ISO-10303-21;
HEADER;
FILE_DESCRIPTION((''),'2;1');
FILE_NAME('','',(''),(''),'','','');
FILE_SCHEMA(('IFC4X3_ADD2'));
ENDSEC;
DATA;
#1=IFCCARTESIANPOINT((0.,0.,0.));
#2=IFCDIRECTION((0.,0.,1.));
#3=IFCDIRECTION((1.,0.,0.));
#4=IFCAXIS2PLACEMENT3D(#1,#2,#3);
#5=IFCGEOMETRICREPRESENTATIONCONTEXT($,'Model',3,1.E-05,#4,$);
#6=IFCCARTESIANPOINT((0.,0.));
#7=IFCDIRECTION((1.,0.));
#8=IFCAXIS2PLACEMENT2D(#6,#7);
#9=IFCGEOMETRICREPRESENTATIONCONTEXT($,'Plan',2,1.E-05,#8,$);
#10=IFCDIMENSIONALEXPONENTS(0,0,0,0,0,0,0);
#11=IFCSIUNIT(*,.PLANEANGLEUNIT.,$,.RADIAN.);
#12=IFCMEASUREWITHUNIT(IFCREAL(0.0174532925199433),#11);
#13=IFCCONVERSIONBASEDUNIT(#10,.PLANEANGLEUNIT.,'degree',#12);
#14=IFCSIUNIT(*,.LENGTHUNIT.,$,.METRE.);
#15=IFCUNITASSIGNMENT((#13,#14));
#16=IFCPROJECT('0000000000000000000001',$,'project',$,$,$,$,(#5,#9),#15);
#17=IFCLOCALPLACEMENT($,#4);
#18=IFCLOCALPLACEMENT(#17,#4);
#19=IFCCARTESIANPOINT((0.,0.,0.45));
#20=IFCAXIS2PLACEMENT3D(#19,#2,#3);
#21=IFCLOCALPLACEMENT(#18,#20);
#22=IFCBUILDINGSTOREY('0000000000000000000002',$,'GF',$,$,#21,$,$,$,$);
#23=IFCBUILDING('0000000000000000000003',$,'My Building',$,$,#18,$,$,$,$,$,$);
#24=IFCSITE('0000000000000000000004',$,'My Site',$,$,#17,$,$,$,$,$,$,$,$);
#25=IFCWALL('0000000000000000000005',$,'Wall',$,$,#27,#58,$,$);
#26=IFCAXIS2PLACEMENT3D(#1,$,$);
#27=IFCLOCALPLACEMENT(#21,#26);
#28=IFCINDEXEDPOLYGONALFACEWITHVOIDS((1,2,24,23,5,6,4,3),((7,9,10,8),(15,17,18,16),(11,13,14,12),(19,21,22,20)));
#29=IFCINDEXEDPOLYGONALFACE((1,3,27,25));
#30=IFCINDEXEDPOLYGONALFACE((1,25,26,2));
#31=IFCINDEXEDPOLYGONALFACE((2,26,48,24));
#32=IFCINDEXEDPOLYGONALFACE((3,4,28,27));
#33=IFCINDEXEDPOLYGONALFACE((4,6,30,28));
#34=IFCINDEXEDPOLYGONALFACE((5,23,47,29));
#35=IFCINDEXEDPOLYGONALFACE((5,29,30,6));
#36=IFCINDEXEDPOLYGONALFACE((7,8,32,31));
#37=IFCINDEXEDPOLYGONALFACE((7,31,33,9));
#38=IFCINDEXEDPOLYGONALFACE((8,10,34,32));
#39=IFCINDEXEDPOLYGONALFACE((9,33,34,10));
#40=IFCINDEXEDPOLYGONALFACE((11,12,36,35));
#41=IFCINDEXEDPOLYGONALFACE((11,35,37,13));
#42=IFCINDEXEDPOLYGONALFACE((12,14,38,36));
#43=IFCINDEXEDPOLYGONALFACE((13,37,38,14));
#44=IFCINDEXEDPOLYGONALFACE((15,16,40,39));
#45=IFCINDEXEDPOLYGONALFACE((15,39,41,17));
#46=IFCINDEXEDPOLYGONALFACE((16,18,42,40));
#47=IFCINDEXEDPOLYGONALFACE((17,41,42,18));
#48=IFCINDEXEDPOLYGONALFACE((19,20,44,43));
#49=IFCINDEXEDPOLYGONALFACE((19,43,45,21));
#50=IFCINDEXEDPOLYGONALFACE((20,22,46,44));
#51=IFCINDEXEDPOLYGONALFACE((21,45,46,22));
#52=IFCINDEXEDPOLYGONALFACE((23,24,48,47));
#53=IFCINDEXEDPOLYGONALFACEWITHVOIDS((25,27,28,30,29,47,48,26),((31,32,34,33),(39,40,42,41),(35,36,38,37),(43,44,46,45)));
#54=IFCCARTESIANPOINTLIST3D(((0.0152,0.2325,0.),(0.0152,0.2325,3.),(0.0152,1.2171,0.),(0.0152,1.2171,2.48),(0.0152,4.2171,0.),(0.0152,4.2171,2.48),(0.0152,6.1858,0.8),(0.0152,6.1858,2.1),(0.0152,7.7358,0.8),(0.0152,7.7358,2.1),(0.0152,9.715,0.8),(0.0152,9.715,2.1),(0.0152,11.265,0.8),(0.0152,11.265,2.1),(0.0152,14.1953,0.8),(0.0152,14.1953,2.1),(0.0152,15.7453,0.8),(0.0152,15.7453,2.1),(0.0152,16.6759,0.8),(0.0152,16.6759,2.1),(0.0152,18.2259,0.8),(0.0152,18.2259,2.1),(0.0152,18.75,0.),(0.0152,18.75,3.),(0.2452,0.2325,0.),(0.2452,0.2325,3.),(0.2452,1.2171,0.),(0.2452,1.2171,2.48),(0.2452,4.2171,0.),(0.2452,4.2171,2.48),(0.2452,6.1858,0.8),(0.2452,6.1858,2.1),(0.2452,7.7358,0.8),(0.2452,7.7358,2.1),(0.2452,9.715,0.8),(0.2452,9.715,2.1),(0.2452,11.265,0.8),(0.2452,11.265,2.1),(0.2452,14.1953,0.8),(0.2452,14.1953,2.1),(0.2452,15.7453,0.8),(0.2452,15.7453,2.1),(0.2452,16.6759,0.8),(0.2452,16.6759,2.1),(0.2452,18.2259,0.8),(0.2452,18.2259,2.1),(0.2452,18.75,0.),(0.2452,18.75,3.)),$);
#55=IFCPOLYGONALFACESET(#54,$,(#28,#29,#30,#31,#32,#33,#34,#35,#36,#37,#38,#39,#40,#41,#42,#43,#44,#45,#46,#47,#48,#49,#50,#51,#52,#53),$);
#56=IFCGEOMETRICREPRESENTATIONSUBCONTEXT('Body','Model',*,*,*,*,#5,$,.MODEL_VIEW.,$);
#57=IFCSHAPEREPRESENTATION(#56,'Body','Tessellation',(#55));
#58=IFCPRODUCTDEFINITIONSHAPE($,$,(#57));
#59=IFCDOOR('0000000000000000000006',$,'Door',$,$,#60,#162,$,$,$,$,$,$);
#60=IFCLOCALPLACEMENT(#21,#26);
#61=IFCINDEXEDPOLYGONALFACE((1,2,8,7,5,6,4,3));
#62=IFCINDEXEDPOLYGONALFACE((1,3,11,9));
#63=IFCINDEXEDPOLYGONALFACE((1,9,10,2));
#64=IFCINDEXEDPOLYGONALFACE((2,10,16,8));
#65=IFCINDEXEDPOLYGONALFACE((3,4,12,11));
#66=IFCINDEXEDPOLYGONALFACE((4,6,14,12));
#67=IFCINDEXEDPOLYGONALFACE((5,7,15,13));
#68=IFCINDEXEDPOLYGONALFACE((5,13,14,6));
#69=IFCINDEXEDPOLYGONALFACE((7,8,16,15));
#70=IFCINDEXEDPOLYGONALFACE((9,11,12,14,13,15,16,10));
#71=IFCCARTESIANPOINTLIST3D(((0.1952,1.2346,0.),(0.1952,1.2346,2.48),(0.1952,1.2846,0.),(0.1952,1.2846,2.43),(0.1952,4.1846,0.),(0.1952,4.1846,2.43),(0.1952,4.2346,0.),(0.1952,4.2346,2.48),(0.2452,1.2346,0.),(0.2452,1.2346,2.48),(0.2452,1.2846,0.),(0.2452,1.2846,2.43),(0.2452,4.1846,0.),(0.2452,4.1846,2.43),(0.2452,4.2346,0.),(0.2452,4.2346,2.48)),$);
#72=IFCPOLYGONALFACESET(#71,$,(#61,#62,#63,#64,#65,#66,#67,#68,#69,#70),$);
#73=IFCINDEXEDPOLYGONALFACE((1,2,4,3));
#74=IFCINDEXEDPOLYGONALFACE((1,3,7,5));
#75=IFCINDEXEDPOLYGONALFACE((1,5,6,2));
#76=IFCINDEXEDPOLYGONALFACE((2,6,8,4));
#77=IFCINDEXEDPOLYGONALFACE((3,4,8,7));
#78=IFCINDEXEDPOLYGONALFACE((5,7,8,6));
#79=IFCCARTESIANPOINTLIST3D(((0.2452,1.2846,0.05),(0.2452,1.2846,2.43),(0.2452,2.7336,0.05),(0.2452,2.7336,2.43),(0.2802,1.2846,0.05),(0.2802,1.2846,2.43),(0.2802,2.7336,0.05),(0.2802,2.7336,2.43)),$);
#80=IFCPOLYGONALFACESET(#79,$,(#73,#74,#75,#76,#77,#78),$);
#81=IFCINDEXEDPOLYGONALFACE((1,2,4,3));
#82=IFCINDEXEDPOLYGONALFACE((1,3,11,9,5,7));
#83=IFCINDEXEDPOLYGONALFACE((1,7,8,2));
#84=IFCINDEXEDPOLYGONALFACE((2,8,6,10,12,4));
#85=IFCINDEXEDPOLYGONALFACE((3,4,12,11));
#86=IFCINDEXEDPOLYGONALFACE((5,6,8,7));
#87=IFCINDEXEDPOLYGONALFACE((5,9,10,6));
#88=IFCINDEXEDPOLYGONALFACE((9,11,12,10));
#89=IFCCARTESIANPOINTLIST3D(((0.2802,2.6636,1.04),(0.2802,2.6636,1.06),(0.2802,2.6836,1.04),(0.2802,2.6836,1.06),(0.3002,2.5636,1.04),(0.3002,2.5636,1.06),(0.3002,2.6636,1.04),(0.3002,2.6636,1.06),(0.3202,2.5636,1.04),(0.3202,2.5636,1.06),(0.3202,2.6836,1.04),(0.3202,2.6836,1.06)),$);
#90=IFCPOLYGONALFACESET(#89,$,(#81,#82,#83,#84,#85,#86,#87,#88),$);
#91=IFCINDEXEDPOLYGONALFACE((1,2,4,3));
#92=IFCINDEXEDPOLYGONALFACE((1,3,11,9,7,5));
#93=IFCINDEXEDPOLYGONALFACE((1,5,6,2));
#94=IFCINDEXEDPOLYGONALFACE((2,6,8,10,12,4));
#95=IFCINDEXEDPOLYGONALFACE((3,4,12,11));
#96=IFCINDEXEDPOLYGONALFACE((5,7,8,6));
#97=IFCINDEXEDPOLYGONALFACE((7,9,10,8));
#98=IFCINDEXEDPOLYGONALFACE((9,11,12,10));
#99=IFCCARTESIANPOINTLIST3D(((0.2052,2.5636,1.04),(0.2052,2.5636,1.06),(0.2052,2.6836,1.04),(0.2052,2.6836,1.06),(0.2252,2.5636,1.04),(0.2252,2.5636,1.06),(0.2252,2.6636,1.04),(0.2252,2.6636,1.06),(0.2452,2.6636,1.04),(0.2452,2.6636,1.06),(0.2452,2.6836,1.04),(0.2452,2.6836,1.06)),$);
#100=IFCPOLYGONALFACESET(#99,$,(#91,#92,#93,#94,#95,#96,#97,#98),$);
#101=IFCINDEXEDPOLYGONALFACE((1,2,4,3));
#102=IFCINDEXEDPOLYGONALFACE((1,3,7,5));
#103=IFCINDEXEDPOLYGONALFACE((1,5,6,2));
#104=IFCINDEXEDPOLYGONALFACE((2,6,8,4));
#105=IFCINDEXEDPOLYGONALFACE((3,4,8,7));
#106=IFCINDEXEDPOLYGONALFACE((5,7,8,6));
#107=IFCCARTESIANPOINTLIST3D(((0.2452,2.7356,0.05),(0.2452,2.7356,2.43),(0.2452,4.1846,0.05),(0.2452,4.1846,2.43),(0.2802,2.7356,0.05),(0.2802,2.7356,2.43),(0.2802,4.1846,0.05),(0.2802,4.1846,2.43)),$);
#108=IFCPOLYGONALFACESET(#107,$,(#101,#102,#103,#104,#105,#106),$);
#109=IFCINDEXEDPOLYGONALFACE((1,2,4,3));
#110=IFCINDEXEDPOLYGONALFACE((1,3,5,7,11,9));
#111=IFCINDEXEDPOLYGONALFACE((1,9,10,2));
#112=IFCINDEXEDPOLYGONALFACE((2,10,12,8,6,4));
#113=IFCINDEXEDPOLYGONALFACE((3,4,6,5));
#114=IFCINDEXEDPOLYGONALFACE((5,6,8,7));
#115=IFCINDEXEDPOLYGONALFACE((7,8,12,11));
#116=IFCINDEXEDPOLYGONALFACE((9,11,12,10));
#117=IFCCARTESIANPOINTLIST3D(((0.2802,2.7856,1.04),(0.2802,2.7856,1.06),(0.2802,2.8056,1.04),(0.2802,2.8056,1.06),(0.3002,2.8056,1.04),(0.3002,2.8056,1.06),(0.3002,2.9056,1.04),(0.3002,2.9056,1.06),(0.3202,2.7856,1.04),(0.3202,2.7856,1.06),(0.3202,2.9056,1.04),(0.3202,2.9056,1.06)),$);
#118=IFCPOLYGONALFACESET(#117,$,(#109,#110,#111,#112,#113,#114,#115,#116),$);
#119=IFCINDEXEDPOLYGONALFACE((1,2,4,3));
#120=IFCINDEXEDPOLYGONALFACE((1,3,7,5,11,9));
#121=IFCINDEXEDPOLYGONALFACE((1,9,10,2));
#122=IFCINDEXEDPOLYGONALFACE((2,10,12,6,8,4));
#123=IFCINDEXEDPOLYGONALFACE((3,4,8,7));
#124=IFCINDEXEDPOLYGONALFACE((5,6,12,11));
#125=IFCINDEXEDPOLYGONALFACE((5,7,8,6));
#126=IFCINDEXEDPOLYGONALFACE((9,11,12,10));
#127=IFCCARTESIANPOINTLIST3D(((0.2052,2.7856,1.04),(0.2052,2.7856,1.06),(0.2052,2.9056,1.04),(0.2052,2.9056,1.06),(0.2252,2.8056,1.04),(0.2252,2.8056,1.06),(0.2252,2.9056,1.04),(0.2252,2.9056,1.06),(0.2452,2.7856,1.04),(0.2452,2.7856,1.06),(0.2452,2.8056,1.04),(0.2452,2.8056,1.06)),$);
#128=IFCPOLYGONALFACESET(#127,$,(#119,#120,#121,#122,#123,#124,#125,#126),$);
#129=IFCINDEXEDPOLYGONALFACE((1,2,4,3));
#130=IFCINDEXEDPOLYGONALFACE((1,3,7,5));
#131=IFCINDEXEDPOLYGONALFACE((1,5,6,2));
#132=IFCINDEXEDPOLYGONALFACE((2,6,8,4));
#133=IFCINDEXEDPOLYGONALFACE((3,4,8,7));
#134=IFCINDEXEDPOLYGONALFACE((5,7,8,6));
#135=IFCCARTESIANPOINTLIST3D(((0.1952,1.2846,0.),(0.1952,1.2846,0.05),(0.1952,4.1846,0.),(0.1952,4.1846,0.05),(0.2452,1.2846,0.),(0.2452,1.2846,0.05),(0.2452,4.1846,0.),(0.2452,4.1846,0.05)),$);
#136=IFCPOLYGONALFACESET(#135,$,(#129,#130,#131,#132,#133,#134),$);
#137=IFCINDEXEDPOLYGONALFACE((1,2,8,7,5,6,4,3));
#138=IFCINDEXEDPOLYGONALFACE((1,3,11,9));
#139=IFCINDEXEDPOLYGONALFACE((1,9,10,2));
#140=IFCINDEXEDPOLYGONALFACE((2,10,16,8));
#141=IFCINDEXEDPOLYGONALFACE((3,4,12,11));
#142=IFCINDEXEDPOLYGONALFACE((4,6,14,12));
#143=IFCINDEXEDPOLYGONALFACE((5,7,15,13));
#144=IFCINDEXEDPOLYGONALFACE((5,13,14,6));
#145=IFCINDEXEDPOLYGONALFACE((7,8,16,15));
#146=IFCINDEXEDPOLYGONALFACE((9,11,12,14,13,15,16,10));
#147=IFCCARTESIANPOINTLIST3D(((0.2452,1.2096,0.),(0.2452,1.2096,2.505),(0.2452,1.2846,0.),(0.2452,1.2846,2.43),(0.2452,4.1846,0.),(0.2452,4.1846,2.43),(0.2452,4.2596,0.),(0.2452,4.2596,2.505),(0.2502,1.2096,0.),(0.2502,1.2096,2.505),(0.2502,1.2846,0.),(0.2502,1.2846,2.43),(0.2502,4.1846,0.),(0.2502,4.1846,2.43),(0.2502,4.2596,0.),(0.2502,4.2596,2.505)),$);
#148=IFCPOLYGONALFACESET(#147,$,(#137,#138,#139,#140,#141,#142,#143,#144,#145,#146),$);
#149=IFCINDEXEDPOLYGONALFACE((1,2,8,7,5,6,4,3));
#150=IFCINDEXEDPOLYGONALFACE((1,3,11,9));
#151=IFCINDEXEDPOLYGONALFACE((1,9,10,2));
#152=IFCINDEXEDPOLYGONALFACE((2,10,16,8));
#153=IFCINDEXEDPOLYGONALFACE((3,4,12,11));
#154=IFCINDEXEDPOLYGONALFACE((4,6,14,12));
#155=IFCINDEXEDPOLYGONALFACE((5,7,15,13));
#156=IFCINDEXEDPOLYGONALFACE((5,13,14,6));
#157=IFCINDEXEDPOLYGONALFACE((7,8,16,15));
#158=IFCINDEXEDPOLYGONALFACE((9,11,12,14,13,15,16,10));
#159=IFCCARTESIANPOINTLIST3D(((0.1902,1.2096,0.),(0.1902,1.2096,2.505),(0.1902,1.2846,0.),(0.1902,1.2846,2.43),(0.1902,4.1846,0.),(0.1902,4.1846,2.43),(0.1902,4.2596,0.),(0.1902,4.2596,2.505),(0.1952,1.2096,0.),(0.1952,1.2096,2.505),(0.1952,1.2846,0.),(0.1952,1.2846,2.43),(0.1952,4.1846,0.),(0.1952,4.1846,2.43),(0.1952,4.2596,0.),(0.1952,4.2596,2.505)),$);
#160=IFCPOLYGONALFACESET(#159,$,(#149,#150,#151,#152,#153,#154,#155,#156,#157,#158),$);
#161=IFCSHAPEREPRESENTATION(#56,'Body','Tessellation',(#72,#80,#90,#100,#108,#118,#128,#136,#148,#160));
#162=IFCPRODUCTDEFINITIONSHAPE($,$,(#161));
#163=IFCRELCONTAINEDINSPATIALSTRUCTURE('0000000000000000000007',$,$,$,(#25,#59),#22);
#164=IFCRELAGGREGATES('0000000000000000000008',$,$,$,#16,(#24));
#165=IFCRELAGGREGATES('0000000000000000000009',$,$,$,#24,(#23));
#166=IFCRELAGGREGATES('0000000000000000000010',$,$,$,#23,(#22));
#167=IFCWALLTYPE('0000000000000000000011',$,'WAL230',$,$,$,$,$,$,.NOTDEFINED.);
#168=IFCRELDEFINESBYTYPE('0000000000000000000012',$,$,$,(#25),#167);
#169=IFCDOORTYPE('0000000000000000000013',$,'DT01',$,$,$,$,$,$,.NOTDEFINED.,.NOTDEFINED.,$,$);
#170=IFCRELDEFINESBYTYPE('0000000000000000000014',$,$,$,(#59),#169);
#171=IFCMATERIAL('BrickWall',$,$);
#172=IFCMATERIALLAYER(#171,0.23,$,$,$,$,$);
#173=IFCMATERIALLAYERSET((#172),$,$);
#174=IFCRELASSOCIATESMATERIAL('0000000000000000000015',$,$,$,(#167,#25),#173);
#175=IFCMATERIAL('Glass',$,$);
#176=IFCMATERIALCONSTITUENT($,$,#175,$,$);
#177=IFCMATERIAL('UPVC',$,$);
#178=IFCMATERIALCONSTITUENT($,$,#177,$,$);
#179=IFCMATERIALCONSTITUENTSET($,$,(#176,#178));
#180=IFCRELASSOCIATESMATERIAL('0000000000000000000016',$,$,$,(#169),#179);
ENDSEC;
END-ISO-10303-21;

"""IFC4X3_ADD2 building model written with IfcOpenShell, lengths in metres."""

from ifc_helpers import new_model, entity, si_unit, converted_unit, frame, origin_with_axes, origin_2d_with_axis, place, context, subcontext, project, spatial, line, indexed_curve, outline, extrude, shape, source, transform, mapped, material, layer, layer_set, layer_usage, constituent, constituent_set, type_object, type_shapes, element, fill, save


model = new_model("IFC4X3_ADD2")

# Units and contexts
model_context = context("Model", 3, precision=1e-05, world=origin_with_axes())
plan_context = context("Plan", 2, precision=1e-05, world=origin_2d_with_axis())
body_context_1 = subcontext(model_context, "Body", "Model", "MODEL_VIEW")
body_context_2 = subcontext(plan_context, "Body", "Plan", "PLAN_VIEW")
ifc_project = project(units=[converted_unit("PLANEANGLEUNIT", "degree", entity("IfcReal", 0.0174532925199433), si_unit("PLANEANGLEUNIT", "RADIAN"), dimensions=[0, 0, 0, 0, 0, 0, 0]), si_unit("LENGTHUNIT", "METRE")], contexts=[model_context, plan_context])

# Site, building, storey
site_placement = place(None, origin_with_axes())
site = spatial("IfcSite", under=ifc_project, at=site_placement, Name="My Site")
building_placement = place(site_placement, origin_with_axes())
building = spatial("IfcBuilding", under=site, at=building_placement, Name="My Building")
storey_placement = place(building_placement, frame((0.0, 0.0, 0.45), z_axis=(0.0, 0.0, 1.0), x_axis=(1.0, 0.0, 0.0)))
storey = spatial("IfcBuildingStorey", under=building, at=storey_placement, Name="GF")

# Shared definitions
ifc_material_1 = material(Name="BrickWall")

# Shared definitions
ifc_layer_1 = layer(ifc_material_1, 0.23)
ifc_layer_set_1 = layer_set([ifc_layer_1])
wall_type_1 = type_object("IfcWallType", Name="WAL230", PredefinedType="NOTDEFINED", material=ifc_layer_set_1)
shared_shape_1 = source(origin_with_axes(), body_context_1, "Body", "SweptSolid", [
    extrude(outline(indexed_curve([(0.0, 0.0), (3.0, 0.0), (3.0, 2.48), (0.0, 2.48)], segments=[line(1, 2, 3, 4, 1)])), frame((0.0, -0.6, 0.0), z_axis=(0.0, -1.0, 0.0), x_axis=(1.0, 0.0, 0.0)), (0.0, 0.0, -1.0), 1.2),
])
ifc_material_2 = material(Name="Glass")
ifc_constituent_1 = constituent(ifc_material_2)
ifc_material_3 = material(Name="UPVC")
ifc_constituent_2 = constituent(ifc_material_3)
ifc_constituent_set = constituent_set(constituents=[ifc_constituent_1, ifc_constituent_2])
door_type_1 = type_object("IfcDoorType", Name="DT01", OperationType="NOTDEFINED", PredefinedType="NOTDEFINED", material=ifc_constituent_set)
shared_shape_2 = source(origin_with_axes(), body_context_1, "Body", "SweptSolid", [
    extrude(outline(indexed_curve([(3.0, 0.0), (3.0, 2.48), (0.0, 2.48), (0.0, 0.0), (0.05, 0.0), (0.05, 2.43), (2.95, 2.43), (2.95, 0.0)], segments=[line(5, 4), line(4, 3), line(3, 2), line(2, 1), line(1, 8), line(8, 7), line(7, 6), line(6, 5)], self_intersect=False)), frame((0.0, 0.0, 0.0), z_axis=(0.0, -1.0, 0.0), x_axis=(1.0, 0.0, 0.0)), (0.0, 0.0, -1.0), 0.05),
    extrude(outline(indexed_curve([(0.0, 0.0), (1.449, 0.0), (1.449, 0.035), (0.0, 0.035)], segments=[line(1, 2, 3, 4, 1)])), frame((0.05, -0.035, 0.05), z_axis=(0.0, 0.0, 1.0), x_axis=(1.0, 0.0, 0.0)), (0.0, 0.0, 1.0), 2.38),
    extrude(outline(indexed_curve([(0.0, 0.0), (0.0, -0.04), (-0.12, -0.04), (-0.12, -0.02), (-0.02, -0.02), (-0.02, 0.0)], segments=[line(1, 2, 3, 4, 5, 6, 1)])), frame((1.449, -0.035, 1.04), z_axis=(0.0, 0.0, 1.0), x_axis=(1.0, 0.0, 0.0)), (0.0, 0.0, 1.0), 0.02),
    extrude(outline(indexed_curve([(0.0, 0.0), (0.0, 0.04), (-0.12, 0.04), (-0.12, 0.02), (-0.02, 0.02), (-0.02, 0.0)], segments=[line(1, 2, 3, 4, 5, 6, 1)])), frame((1.449, 0.0, 1.04), z_axis=(0.0, 0.0, 1.0), x_axis=(1.0, 0.0, 0.0)), (0.0, 0.0, 1.0), 0.02),
    extrude(outline(indexed_curve([(0.0, 0.0), (-1.449, 0.0), (-1.449, 0.035), (0.0, 0.035)], segments=[line(1, 2, 3, 4, 1)])), frame((2.95, -0.035, 0.05), z_axis=(0.0, 0.0, 1.0), x_axis=(1.0, 0.0, 0.0)), (0.0, 0.0, 1.0), 2.38),
    extrude(outline(indexed_curve([(0.0, 0.0), (0.0, -0.04), (0.12, -0.04), (0.12, -0.02), (0.02, -0.02), (0.02, 0.0)], segments=[line(1, 2, 3, 4, 5, 6, 1)])), frame((1.551, -0.035, 1.04), z_axis=(0.0, 0.0, 1.0), x_axis=(1.0, 0.0, 0.0)), (0.0, 0.0, 1.0), 0.02),
    extrude(outline(indexed_curve([(0.0, 0.0), (0.0, 0.04), (0.12, 0.04), (0.12, 0.02), (0.02, 0.02), (0.02, 0.0)], segments=[line(1, 2, 3, 4, 5, 6, 1)])), frame((1.551, 0.0, 1.04), z_axis=(0.0, 0.0, 1.0), x_axis=(1.0, 0.0, 0.0)), (0.0, 0.0, 1.0), 0.02),
    extrude(outline(indexed_curve([(0.0, 0.0), (2.9, 0.0), (2.9, 0.05), (0.0, 0.05)], segments=[line(1, 2, 3, 4, 1)])), frame((0.05, 0.0, 0.0), z_axis=(0.0, 0.0, 1.0), x_axis=(1.0, 0.0, 0.0)), (0.0, 0.0, 1.0), 0.05),
    extrude(outline(indexed_curve([(0.0, 0.0), (0.0, 2.505), (3.05, 2.505), (3.05, 0.0), (2.975, 0.0), (2.975, 2.43), (0.075, 2.43), (0.075, 0.0)], segments=[line(1, 2, 3, 4, 5, 6, 7, 8, 1)])), frame((-0.025, -0.005, 0.0), z_axis=(0.0, -1.0, 0.0), x_axis=(1.0, 0.0, 0.0)), (0.0, 0.0, -1.0), 0.005),
    extrude(outline(indexed_curve([(0.0, 0.0), (0.0, 2.505), (3.05, 2.505), (3.05, 0.0), (2.975, 0.0), (2.975, 2.43), (0.075, 2.43), (0.075, 0.0)], segments=[line(1, 2, 3, 4, 5, 6, 7, 8, 1)])), frame((-0.025, 0.05, 0.0), z_axis=(0.0, -1.0, 0.0), x_axis=(1.0, 0.0, 0.0)), (0.0, 0.0, -1.0), 0.005),
])
shared_shape_3 = source(origin_with_axes(), body_context_2, "Body", "Curve2D", [
    entity("IfcIndexedPolyCurve", entity("IfcCartesianPointList2D", [[0.0, 0.0], [0.05, 0.0], [0.05, 0.05], [0.0, 0.05]]), [entity("IfcLineIndex", [1, 2, 3, 4, 1])]),
    entity("IfcIndexedPolyCurve", entity("IfcCartesianPointList2D", [[3.0, 0.0], [2.95, 0.0], [2.95, 0.05], [3.0, 0.05]]), [entity("IfcLineIndex", [1, 2, 3, 4, 1])]),
    entity("IfcIndexedPolyCurve", entity("IfcCartesianPointList2D", [[-0.675, -0.035], [0.775, -0.035], [0.775, 0.0], [-0.675, 0.0]]), [entity("IfcLineIndex", [1, 2, 3, 4, 1])]),
    entity("IfcIndexedPolyCurve", entity("IfcCartesianPointList2D", [[3.675, -0.035], [2.225, -0.035], [2.225, 0.0], [3.675, 0.0]]), [entity("IfcLineIndex", [1, 2, 3, 4, 1])]),
])
type_shapes(door_type_1, [shared_shape_2, shared_shape_3])

# Wall, openings, door
ifc_layer_usage_1 = layer_usage(ifc_layer_set_1, "AXIS2", "POSITIVE", 0.0)
wall_1_placement = place(storey_placement, frame((0.2452, 0.2325, 0.0), z_axis=(0.0, 0.0, 1.0), x_axis=(0.0, 1.0, 0.0)))
wall_1 = element("IfcWall", 1, at=wall_1_placement, inside=storey, type_object=wall_type_1, material=ifc_layer_usage_1, Name="Wall", context=body_context_1, shape_type="SweptSolid", body=[
    extrude(outline(indexed_curve([(0.0, 0.0), (0.0, 0.23), (18.5175, 0.23), (18.5175, 0.0), (0.0, 0.0)], self_intersect=False)), origin_with_axes(), (0.0, 0.0, 1.0), 3.0),
])
opening_1_placement = place(wall_1_placement, frame((0.9846, 0.0302, 0.0), z_axis=(0.0, 0.0, 1.0), x_axis=(1.0, 0.0, 0.0)))
opening_1 = element("IfcOpeningElement", 2, at=opening_1_placement, cuts=wall_1, PredefinedType="OPENING", context=body_context_1, shape_type="MappedRepresentation", body=[
    mapped(shared_shape_1, transform((0.0, 0.0, 0.0), x_axis=(1.0, 0.0, 0.0), y_axis=(0.0, 1.0, 0.0), z_axis=(0.0, 0.0, 1.0), scale=1.0)),
])
shared_shape_4 = source(origin_with_axes(), body_context_1, "Body", "SweptSolid", [
    extrude(outline(indexed_curve([(0.0, 0.0), (1.55, 0.0), (1.55, 1.3), (0.0, 1.3)], segments=[line(1, 2, 3, 4, 1)])), frame((-0.775, -0.6, 0.0), z_axis=(0.0, -1.0, 0.0), x_axis=(1.0, 0.0, 0.0)), (0.0, 0.0, -1.0), 1.2),
])
opening_2_placement = place(wall_1_placement, frame((6.7283, 0.0, 0.8), z_axis=(0.0, 0.0, 1.0), x_axis=(1.0, 0.0, 0.0)))
element("IfcOpeningElement", 3, at=opening_2_placement, cuts=wall_1, PredefinedType="OPENING", context=body_context_1, shape_type="MappedRepresentation", body=[
    mapped(shared_shape_4, transform((0.0, 0.0, 0.0), x_axis=(1.0, 0.0, 0.0), y_axis=(0.0, 1.0, 0.0), z_axis=(0.0, 0.0, 1.0), scale=1.0)),
])
opening_3_placement = place(wall_1_placement, frame((10.2575, 0.0, 0.8), z_axis=(0.0, 0.0, 1.0), x_axis=(1.0, 0.0, 0.0)))
element("IfcOpeningElement", 4, at=opening_3_placement, cuts=wall_1, PredefinedType="OPENING", context=body_context_1, shape_type="MappedRepresentation", body=[
    mapped(shared_shape_4, transform((0.0, 0.0, 0.0), x_axis=(1.0, 0.0, 0.0), y_axis=(0.0, 1.0, 0.0), z_axis=(0.0, 0.0, 1.0), scale=1.0)),
])
opening_4_placement = place(wall_1_placement, frame((14.7378, 0.0, 0.8), z_axis=(0.0, 0.0, 1.0), x_axis=(1.0, 0.0, 0.0)))
element("IfcOpeningElement", 5, at=opening_4_placement, cuts=wall_1, PredefinedType="OPENING", context=body_context_1, shape_type="MappedRepresentation", body=[
    mapped(shared_shape_4, transform((0.0, 0.0, 0.0), x_axis=(1.0, 0.0, 0.0), y_axis=(0.0, 1.0, 0.0), z_axis=(0.0, 0.0, 1.0), scale=1.0)),
])
opening_5_placement = place(wall_1_placement, frame((17.2184, 0.0, 0.8), z_axis=(0.0, 0.0, 1.0), x_axis=(1.0, 0.0, 0.0)))
element("IfcOpeningElement", 6, at=opening_5_placement, cuts=wall_1, PredefinedType="OPENING", context=body_context_1, shape_type="MappedRepresentation", body=[
    mapped(shared_shape_4, transform((0.0, 0.0, 0.0), x_axis=(1.0, 0.0, 0.0), y_axis=(0.0, 1.0, 0.0), z_axis=(0.0, 0.0, 1.0), scale=1.0)),
])
door_1_placement = place(opening_1_placement, frame((0.0175, -0.0302, 0.0), z_axis=(0.0, 0.0, 1.0), x_axis=(1.0, 0.0, 0.0)))
door_1 = element("IfcDoor", 7, at=door_1_placement, inside=storey, type_object=door_type_1, Name="Door", shapes=[
    shape(body_context_1, "Body", "MappedRepresentation", [mapped(shared_shape_2, transform((0.0, 0.0, 0.0), x_axis=(1.0, 0.0, 0.0), y_axis=(0.0, 1.0, 0.0), z_axis=(0.0, 0.0, 1.0), scale=1.0))]),
    shape(body_context_2, "Body", "MappedRepresentation", [mapped(shared_shape_3, transform((0.0, 0.0, 0.0), x_axis=(1.0, 0.0, 0.0), y_axis=(0.0, 1.0, 0.0), z_axis=(0.0, 0.0, 1.0), scale=1.0))]),
])
fill(opening_1, door_1)

save(model, "model.ifc")
